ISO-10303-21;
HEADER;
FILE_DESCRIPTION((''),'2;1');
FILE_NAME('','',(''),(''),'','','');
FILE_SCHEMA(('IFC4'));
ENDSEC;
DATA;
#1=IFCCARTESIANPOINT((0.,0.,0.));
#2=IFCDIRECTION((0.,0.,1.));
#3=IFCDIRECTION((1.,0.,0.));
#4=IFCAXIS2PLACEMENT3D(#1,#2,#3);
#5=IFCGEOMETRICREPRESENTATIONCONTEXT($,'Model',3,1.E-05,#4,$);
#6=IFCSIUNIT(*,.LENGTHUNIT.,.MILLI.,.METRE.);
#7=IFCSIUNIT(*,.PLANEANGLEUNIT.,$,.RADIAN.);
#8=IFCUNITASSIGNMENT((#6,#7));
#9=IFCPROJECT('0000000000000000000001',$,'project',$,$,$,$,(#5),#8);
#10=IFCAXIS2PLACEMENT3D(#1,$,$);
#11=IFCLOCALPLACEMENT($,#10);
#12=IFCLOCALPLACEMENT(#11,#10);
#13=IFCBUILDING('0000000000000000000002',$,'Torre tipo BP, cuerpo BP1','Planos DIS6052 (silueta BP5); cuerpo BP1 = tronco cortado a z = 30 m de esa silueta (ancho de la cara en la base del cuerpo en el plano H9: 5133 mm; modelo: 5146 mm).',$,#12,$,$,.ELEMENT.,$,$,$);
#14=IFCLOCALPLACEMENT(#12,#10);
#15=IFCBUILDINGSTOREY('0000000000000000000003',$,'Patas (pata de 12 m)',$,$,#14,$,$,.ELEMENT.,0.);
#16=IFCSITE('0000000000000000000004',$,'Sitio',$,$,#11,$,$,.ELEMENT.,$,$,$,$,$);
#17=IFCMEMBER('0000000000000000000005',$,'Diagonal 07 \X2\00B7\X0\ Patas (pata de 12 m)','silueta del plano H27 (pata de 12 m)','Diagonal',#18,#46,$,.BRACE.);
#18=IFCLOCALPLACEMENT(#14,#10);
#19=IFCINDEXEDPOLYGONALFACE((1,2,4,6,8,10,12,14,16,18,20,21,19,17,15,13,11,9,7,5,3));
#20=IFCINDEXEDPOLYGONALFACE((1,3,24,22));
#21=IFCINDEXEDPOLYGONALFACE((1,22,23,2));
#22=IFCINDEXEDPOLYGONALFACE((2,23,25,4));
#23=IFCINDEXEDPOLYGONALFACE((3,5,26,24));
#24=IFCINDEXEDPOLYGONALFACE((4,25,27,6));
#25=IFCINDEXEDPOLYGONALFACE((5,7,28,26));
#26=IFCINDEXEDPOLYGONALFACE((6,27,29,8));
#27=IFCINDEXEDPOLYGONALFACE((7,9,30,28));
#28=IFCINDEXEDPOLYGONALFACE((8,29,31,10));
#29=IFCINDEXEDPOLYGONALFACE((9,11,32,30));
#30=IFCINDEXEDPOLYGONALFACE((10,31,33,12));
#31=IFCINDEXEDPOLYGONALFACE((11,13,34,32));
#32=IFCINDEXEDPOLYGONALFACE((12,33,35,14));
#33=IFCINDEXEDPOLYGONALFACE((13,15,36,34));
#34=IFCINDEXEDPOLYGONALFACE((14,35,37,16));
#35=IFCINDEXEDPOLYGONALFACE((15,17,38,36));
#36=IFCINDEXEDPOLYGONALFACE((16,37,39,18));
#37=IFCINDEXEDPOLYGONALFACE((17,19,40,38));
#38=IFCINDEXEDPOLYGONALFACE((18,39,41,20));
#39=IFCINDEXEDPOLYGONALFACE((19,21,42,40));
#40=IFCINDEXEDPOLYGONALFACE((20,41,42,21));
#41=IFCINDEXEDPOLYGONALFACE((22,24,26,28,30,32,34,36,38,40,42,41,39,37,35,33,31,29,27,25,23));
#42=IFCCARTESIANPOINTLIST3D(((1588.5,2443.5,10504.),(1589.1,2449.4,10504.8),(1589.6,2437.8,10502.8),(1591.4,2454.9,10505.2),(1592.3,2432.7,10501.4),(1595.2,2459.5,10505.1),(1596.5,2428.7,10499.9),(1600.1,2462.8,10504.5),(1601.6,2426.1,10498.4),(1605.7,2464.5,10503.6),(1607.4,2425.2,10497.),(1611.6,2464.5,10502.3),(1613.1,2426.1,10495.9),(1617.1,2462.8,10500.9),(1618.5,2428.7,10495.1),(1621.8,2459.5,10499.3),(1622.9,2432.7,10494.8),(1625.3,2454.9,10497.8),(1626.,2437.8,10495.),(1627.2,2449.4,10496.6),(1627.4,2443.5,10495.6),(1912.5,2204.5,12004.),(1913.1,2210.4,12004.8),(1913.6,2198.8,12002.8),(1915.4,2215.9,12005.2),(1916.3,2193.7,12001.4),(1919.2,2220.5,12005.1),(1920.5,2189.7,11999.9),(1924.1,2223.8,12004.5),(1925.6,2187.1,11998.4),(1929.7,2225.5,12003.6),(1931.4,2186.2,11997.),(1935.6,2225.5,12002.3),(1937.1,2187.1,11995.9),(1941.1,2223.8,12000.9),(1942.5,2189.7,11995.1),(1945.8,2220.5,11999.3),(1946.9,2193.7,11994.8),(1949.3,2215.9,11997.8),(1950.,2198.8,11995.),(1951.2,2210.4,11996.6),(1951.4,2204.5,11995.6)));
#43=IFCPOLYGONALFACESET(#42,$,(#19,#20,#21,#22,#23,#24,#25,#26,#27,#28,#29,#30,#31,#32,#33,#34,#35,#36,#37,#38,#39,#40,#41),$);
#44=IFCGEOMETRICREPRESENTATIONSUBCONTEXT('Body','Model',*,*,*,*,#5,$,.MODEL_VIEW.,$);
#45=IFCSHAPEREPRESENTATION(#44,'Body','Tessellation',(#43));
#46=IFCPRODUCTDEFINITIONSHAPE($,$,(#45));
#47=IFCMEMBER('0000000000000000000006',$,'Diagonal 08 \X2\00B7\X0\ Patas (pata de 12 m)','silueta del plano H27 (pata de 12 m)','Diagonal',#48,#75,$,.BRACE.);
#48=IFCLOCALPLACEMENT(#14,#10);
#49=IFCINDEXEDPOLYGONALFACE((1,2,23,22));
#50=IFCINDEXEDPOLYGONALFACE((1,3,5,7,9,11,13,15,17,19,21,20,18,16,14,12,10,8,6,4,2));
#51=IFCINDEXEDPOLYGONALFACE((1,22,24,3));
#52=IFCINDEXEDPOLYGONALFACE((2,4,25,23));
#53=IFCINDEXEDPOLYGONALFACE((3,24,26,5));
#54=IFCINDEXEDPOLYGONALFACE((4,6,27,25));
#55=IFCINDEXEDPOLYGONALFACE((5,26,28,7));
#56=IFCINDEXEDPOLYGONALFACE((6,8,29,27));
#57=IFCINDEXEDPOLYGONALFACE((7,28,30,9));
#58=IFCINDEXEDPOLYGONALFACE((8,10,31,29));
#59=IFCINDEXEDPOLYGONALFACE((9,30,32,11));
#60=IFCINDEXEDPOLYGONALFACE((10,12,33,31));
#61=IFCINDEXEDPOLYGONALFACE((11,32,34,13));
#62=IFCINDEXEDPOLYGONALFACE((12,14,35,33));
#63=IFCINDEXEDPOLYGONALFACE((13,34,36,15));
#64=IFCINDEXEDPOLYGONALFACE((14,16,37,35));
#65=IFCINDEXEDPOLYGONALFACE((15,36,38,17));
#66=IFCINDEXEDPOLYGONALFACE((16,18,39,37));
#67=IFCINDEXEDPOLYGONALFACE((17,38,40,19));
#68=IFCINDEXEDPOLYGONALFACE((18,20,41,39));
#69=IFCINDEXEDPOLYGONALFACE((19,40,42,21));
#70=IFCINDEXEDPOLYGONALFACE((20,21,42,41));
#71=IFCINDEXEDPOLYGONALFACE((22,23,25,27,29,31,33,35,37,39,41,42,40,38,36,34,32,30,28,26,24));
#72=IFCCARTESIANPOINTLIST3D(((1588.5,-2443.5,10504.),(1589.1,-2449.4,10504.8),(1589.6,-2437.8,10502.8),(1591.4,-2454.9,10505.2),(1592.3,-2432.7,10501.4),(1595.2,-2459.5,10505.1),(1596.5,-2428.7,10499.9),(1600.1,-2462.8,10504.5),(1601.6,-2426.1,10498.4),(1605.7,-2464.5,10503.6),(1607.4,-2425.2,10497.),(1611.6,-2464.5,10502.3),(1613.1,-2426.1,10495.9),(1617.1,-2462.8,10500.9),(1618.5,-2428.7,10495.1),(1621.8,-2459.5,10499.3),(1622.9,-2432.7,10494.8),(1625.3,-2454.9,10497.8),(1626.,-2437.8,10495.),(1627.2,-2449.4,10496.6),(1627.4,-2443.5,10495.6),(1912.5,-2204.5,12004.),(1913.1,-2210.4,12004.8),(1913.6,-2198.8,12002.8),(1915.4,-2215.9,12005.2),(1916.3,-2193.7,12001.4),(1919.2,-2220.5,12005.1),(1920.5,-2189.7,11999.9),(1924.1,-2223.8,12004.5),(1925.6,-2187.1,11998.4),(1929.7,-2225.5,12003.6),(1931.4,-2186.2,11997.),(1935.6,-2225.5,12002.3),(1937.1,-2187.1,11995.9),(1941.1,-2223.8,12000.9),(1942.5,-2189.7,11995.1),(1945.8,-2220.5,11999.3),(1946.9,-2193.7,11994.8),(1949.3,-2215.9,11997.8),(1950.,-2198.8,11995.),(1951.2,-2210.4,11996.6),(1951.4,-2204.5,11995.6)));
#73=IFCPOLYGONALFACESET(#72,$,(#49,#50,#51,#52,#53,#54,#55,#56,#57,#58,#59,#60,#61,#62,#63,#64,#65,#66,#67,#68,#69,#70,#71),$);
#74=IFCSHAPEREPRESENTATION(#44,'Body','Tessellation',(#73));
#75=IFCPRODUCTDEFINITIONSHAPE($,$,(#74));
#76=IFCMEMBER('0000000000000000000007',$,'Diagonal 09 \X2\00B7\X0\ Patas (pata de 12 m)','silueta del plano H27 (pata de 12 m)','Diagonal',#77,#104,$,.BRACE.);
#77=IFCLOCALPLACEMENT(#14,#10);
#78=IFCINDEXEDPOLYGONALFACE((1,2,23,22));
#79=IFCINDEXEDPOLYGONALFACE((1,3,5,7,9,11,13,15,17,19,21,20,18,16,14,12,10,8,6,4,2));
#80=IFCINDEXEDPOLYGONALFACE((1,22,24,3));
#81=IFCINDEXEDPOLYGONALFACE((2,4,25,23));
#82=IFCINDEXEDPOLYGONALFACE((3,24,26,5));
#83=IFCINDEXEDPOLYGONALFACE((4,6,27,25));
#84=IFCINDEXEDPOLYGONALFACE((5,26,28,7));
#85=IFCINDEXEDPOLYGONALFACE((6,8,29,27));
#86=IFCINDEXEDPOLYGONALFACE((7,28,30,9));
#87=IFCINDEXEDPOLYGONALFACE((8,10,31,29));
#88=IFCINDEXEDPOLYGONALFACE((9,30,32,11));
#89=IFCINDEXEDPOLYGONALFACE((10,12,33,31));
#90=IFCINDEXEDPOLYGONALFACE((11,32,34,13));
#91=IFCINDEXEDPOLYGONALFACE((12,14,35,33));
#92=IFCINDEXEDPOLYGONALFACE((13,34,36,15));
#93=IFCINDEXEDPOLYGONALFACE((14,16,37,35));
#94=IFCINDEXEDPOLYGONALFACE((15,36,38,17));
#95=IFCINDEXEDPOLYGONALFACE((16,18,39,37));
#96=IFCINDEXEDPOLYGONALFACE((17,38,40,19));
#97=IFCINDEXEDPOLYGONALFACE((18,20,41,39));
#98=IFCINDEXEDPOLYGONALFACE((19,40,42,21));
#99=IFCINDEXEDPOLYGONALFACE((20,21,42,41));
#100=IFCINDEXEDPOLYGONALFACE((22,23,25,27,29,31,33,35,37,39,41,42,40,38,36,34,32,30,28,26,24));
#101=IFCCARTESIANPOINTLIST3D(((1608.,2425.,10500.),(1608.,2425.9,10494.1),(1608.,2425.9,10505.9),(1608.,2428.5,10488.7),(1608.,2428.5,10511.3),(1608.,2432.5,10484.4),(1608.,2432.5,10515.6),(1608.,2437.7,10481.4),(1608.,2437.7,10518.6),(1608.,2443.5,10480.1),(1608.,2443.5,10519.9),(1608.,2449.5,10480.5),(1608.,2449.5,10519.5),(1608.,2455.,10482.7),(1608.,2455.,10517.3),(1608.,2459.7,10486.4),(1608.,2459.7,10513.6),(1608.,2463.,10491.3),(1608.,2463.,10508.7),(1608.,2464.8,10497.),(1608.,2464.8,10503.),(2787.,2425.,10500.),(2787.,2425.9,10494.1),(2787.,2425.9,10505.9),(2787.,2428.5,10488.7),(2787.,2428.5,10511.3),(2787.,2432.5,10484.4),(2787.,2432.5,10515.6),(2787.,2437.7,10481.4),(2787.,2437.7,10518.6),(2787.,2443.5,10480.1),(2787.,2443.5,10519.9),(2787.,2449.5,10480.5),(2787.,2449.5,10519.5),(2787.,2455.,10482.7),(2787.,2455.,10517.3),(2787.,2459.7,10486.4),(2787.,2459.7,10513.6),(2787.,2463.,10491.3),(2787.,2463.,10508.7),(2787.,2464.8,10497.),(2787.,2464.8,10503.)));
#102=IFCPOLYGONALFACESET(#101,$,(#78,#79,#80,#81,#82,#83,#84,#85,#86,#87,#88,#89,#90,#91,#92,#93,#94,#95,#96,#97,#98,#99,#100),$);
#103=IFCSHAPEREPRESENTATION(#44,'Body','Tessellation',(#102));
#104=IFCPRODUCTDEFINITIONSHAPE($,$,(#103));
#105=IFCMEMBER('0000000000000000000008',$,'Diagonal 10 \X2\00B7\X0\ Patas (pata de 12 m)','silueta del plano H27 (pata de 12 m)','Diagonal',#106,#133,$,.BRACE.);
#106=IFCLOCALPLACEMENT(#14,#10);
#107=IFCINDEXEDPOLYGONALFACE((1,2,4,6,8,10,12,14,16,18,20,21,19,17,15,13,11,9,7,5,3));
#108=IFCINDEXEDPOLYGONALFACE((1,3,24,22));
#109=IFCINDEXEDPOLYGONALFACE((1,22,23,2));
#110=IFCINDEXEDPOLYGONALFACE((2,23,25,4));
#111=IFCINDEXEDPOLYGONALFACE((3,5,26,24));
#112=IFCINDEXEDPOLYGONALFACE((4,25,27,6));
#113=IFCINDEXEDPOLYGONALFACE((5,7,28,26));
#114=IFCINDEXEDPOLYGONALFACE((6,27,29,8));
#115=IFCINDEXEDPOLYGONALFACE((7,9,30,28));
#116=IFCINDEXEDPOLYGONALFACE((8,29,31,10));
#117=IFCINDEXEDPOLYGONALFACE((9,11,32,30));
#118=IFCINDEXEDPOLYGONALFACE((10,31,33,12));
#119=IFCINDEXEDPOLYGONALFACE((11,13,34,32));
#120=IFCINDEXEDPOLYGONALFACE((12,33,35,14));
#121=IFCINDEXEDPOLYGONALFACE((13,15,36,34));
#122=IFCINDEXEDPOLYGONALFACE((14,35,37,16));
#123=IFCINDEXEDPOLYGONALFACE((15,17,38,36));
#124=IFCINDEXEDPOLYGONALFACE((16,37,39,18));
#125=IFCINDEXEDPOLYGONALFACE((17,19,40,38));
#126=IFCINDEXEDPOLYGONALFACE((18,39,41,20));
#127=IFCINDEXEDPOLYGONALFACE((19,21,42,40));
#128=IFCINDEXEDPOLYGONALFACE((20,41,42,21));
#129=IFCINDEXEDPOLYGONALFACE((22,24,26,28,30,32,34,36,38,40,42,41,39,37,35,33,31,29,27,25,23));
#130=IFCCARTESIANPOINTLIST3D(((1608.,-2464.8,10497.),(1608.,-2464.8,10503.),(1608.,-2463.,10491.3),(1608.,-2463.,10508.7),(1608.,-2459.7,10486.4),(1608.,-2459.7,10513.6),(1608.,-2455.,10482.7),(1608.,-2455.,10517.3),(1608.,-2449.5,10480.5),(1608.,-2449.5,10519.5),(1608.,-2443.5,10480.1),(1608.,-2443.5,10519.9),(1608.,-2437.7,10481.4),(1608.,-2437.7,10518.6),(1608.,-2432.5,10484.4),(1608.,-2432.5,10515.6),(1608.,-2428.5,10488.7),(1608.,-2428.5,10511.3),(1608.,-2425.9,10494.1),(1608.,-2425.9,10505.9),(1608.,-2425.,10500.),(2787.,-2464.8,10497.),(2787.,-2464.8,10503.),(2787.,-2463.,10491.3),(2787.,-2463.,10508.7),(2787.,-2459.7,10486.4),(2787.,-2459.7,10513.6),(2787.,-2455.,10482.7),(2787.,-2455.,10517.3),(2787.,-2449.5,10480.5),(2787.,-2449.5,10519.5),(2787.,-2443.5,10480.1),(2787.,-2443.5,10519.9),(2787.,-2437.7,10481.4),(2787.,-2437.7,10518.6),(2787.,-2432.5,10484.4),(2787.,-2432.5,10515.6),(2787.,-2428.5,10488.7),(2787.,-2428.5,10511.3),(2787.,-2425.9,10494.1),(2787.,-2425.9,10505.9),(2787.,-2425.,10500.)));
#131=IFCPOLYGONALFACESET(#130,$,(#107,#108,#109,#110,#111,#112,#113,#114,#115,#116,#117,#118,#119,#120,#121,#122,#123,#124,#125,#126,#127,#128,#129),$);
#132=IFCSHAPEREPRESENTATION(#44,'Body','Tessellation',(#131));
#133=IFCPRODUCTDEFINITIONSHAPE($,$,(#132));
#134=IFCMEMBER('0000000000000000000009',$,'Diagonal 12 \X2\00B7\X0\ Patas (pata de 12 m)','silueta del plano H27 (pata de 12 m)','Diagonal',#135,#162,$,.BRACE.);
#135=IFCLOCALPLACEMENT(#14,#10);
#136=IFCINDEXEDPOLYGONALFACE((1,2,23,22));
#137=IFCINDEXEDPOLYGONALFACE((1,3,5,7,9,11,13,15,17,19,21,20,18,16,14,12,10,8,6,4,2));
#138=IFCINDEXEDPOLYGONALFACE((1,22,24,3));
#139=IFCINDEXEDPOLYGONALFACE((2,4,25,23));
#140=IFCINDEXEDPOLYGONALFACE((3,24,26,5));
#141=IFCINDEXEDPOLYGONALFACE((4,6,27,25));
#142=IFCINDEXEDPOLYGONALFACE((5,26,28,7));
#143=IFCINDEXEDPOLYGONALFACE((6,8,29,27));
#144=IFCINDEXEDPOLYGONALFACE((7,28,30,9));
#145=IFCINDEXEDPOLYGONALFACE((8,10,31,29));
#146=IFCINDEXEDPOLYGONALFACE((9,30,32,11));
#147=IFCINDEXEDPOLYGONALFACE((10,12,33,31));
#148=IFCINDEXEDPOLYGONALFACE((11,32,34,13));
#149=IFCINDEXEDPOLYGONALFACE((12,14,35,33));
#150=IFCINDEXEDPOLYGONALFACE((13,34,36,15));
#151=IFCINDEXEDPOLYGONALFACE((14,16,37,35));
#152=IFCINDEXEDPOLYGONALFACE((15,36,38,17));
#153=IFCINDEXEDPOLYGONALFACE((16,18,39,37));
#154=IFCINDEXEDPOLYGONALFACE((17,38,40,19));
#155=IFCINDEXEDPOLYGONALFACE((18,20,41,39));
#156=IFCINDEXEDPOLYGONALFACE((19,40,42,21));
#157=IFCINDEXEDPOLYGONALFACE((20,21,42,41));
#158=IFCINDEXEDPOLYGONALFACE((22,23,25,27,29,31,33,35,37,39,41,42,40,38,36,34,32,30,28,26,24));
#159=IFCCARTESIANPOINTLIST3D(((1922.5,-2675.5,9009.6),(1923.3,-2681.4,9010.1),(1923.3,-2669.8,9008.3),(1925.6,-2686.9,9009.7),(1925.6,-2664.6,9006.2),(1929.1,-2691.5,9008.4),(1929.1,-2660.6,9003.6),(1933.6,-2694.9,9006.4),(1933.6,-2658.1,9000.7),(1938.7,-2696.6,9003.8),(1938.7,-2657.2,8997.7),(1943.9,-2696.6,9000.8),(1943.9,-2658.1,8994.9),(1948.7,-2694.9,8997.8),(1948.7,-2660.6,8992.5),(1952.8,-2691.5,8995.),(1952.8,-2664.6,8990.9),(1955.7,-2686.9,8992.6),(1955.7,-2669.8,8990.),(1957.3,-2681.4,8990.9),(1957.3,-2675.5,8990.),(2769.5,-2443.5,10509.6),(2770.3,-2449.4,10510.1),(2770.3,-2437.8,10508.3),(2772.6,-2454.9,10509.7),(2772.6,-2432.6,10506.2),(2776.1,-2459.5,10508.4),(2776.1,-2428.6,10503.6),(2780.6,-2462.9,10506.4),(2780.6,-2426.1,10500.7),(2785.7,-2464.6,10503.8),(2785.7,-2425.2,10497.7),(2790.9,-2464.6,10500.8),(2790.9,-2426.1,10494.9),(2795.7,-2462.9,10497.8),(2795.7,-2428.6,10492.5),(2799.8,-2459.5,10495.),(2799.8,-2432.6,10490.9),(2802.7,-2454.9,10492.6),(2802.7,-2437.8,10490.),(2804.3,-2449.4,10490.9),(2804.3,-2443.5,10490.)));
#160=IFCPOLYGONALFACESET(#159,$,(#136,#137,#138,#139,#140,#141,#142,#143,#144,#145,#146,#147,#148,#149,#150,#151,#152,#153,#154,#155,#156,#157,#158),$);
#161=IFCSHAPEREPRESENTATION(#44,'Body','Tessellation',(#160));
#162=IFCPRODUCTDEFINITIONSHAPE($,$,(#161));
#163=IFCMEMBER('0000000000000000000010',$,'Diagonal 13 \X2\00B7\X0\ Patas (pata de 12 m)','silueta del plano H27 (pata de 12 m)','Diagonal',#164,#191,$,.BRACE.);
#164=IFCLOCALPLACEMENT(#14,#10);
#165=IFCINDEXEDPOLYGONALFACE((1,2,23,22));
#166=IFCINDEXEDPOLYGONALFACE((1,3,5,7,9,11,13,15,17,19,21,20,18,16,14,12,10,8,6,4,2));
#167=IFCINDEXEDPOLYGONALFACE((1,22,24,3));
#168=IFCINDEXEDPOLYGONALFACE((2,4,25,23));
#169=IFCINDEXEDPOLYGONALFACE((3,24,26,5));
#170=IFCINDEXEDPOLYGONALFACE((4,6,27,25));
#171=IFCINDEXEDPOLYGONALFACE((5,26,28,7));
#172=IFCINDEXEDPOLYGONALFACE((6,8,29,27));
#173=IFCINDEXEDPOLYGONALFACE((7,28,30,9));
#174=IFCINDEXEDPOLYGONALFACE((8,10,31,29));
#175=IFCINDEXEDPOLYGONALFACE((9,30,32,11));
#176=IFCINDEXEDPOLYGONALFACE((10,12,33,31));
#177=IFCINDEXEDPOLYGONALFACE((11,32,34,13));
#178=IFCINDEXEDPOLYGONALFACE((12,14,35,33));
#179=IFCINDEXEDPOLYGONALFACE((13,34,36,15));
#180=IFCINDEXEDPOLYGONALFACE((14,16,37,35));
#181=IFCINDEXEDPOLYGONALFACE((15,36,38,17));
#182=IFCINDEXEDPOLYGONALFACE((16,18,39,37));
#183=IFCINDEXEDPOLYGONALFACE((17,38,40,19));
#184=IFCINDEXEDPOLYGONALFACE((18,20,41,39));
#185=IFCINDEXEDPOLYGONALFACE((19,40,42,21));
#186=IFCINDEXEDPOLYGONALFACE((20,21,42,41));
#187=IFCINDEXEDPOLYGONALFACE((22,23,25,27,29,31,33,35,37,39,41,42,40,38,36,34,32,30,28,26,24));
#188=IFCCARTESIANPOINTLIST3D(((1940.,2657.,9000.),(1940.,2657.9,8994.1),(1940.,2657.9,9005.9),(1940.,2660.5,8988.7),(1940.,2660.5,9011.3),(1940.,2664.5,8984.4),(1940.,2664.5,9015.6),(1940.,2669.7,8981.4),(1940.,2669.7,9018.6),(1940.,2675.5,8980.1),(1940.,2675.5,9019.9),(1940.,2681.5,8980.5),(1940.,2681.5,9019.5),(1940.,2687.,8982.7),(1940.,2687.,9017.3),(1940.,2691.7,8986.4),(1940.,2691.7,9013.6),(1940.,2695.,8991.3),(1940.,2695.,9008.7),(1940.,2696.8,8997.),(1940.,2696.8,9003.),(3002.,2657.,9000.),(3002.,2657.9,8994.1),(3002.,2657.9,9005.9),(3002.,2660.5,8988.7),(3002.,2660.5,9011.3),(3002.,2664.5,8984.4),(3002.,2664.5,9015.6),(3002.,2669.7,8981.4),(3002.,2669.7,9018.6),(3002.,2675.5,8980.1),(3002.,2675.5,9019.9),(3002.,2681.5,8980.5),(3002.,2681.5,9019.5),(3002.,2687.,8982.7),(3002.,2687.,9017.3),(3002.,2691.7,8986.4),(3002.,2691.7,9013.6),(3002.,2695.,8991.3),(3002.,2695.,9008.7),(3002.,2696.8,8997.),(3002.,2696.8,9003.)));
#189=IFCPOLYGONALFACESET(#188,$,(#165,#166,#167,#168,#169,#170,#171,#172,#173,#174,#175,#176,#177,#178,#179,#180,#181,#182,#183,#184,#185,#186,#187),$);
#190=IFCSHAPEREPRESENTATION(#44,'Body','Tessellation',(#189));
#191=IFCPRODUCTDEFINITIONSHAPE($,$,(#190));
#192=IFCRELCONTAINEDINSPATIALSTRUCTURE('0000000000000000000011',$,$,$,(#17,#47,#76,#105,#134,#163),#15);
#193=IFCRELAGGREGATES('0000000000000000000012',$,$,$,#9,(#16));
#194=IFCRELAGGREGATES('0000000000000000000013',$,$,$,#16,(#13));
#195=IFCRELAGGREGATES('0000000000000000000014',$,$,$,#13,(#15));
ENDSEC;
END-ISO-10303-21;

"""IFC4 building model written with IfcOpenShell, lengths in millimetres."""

from ifc_helpers import new_model, si_unit, frame, origin, origin_with_axes, place, context, subcontext, project, spatial, circle, extrude, element, save


model = new_model("IFC4")

# Units and contexts
model_context = context("Model", 3, precision=1e-05, world=origin_with_axes())
body_context = subcontext(model_context, "Body", "Model", "MODEL_VIEW")
ifc_project = project(units=[si_unit("LENGTHUNIT", "METRE", prefix="MILLI"), si_unit("PLANEANGLEUNIT", "RADIAN")], contexts=[model_context])

# Site, building, storey
site_placement = place(None, origin())
site = spatial("IfcSite", under=ifc_project, at=site_placement, Name="Sitio", CompositionType="ELEMENT")
building_placement = place(site_placement, origin())
building = spatial("IfcBuilding", under=site, at=building_placement, Name="Torre tipo BP, cuerpo BP1", Description="Planos DIS6052 (silueta BP5); cuerpo BP1 = tronco cortado a z = 30 m de esa silueta (ancho de la cara en la base del cuerpo en el plano H9: 5133 mm; modelo: 5146 mm).", CompositionType="ELEMENT")
storey_placement = place(building_placement, origin())
storey = spatial("IfcBuildingStorey", under=building, at=storey_placement, Name="Patas (pata de 12 m)", CompositionType="ELEMENT", Elevation=0.0)

# Members
for number, where, z_axis, x_axis, name in (
    (1, (1932.0, 2206.0, 12000.0), (-0.208616, 0.153886, -0.965815), (-0.03249, -0.988089, -0.150418), "Diagonal 07 · Patas (pata de 12 m)"),
    (2, (1932.0, -2206.0, 12000.0), (-0.208616, -0.153886, -0.965815), (-0.03249, 0.988089, -0.150418), "Diagonal 08 · Patas (pata de 12 m)"),
):
    element("IfcMember", number, at=place(storey_placement, frame(where, z_axis=z_axis, x_axis=x_axis)), inside=storey, Name=name, Description="silueta del plano H27 (pata de 12 m)", ObjectType="Diagonal", PredefinedType="BRACE", context=body_context, shape_type="SweptSolid", body=[
        extrude(circle(Radius=20.0), None, (0.0, 0.0, 1.0), 1553.1),
    ])
for number, where, z_axis, x_axis, name in (
    (3, (1608.0, 2445.0, 10500.0), (1.0, 0.0, 0.0), (0.0, -1.0, 0.0), "Diagonal 09 · Patas (pata de 12 m)"),
    (4, (1608.0, -2445.0, 10500.0), (1.0, 0.0, 0.0), (0.0, 1.0, 0.0), "Diagonal 10 · Patas (pata de 12 m)"),
):
    element("IfcMember", number, at=place(storey_placement, frame(where, z_axis=z_axis, x_axis=x_axis)), inside=storey, Name=name, Description="silueta del plano H27 (pata de 12 m)", ObjectType="Diagonal", PredefinedType="BRACE", context=body_context, shape_type="SweptSolid", body=[
        extrude(circle(Radius=20.0), None, (0.0, 0.0, 1.0), 1179.0),
    ])
member_1_placement = place(storey_placement, frame((1940.0, -2677.0, 9000.0), z_axis=(0.487294, 0.133474, 0.862977), x_axis=(-0.065628, 0.991052, -0.116225)))
element("IfcMember", 5, at=member_1_placement, inside=storey, Name="Diagonal 12 · Patas (pata de 12 m)", Description="silueta del plano H27 (pata de 12 m)", ObjectType="Diagonal", PredefinedType="BRACE", context=body_context, shape_type="SweptSolid", body=[
    extrude(circle(Radius=20.0), None, (0.0, 0.0, 1.0), 1738.2),
])
for number, where, z_axis, x_axis, name in (
    (6, (3002.0, 2677.0, 9000.0), (-1.0, 0.0, 0.0), (0.0, -1.0, 0.0), "Diagonal 13 · Patas (pata de 12 m)"),
):
    element("IfcMember", number, at=place(storey_placement, frame(where, z_axis=z_axis, x_axis=x_axis)), inside=storey, Name=name, Description="silueta del plano H27 (pata de 12 m)", ObjectType="Diagonal", PredefinedType="BRACE", context=body_context, shape_type="SweptSolid", body=[
        extrude(circle(Radius=20.0), None, (0.0, 0.0, 1.0), 1062.0),
    ])

save(model, "model.ifc")
